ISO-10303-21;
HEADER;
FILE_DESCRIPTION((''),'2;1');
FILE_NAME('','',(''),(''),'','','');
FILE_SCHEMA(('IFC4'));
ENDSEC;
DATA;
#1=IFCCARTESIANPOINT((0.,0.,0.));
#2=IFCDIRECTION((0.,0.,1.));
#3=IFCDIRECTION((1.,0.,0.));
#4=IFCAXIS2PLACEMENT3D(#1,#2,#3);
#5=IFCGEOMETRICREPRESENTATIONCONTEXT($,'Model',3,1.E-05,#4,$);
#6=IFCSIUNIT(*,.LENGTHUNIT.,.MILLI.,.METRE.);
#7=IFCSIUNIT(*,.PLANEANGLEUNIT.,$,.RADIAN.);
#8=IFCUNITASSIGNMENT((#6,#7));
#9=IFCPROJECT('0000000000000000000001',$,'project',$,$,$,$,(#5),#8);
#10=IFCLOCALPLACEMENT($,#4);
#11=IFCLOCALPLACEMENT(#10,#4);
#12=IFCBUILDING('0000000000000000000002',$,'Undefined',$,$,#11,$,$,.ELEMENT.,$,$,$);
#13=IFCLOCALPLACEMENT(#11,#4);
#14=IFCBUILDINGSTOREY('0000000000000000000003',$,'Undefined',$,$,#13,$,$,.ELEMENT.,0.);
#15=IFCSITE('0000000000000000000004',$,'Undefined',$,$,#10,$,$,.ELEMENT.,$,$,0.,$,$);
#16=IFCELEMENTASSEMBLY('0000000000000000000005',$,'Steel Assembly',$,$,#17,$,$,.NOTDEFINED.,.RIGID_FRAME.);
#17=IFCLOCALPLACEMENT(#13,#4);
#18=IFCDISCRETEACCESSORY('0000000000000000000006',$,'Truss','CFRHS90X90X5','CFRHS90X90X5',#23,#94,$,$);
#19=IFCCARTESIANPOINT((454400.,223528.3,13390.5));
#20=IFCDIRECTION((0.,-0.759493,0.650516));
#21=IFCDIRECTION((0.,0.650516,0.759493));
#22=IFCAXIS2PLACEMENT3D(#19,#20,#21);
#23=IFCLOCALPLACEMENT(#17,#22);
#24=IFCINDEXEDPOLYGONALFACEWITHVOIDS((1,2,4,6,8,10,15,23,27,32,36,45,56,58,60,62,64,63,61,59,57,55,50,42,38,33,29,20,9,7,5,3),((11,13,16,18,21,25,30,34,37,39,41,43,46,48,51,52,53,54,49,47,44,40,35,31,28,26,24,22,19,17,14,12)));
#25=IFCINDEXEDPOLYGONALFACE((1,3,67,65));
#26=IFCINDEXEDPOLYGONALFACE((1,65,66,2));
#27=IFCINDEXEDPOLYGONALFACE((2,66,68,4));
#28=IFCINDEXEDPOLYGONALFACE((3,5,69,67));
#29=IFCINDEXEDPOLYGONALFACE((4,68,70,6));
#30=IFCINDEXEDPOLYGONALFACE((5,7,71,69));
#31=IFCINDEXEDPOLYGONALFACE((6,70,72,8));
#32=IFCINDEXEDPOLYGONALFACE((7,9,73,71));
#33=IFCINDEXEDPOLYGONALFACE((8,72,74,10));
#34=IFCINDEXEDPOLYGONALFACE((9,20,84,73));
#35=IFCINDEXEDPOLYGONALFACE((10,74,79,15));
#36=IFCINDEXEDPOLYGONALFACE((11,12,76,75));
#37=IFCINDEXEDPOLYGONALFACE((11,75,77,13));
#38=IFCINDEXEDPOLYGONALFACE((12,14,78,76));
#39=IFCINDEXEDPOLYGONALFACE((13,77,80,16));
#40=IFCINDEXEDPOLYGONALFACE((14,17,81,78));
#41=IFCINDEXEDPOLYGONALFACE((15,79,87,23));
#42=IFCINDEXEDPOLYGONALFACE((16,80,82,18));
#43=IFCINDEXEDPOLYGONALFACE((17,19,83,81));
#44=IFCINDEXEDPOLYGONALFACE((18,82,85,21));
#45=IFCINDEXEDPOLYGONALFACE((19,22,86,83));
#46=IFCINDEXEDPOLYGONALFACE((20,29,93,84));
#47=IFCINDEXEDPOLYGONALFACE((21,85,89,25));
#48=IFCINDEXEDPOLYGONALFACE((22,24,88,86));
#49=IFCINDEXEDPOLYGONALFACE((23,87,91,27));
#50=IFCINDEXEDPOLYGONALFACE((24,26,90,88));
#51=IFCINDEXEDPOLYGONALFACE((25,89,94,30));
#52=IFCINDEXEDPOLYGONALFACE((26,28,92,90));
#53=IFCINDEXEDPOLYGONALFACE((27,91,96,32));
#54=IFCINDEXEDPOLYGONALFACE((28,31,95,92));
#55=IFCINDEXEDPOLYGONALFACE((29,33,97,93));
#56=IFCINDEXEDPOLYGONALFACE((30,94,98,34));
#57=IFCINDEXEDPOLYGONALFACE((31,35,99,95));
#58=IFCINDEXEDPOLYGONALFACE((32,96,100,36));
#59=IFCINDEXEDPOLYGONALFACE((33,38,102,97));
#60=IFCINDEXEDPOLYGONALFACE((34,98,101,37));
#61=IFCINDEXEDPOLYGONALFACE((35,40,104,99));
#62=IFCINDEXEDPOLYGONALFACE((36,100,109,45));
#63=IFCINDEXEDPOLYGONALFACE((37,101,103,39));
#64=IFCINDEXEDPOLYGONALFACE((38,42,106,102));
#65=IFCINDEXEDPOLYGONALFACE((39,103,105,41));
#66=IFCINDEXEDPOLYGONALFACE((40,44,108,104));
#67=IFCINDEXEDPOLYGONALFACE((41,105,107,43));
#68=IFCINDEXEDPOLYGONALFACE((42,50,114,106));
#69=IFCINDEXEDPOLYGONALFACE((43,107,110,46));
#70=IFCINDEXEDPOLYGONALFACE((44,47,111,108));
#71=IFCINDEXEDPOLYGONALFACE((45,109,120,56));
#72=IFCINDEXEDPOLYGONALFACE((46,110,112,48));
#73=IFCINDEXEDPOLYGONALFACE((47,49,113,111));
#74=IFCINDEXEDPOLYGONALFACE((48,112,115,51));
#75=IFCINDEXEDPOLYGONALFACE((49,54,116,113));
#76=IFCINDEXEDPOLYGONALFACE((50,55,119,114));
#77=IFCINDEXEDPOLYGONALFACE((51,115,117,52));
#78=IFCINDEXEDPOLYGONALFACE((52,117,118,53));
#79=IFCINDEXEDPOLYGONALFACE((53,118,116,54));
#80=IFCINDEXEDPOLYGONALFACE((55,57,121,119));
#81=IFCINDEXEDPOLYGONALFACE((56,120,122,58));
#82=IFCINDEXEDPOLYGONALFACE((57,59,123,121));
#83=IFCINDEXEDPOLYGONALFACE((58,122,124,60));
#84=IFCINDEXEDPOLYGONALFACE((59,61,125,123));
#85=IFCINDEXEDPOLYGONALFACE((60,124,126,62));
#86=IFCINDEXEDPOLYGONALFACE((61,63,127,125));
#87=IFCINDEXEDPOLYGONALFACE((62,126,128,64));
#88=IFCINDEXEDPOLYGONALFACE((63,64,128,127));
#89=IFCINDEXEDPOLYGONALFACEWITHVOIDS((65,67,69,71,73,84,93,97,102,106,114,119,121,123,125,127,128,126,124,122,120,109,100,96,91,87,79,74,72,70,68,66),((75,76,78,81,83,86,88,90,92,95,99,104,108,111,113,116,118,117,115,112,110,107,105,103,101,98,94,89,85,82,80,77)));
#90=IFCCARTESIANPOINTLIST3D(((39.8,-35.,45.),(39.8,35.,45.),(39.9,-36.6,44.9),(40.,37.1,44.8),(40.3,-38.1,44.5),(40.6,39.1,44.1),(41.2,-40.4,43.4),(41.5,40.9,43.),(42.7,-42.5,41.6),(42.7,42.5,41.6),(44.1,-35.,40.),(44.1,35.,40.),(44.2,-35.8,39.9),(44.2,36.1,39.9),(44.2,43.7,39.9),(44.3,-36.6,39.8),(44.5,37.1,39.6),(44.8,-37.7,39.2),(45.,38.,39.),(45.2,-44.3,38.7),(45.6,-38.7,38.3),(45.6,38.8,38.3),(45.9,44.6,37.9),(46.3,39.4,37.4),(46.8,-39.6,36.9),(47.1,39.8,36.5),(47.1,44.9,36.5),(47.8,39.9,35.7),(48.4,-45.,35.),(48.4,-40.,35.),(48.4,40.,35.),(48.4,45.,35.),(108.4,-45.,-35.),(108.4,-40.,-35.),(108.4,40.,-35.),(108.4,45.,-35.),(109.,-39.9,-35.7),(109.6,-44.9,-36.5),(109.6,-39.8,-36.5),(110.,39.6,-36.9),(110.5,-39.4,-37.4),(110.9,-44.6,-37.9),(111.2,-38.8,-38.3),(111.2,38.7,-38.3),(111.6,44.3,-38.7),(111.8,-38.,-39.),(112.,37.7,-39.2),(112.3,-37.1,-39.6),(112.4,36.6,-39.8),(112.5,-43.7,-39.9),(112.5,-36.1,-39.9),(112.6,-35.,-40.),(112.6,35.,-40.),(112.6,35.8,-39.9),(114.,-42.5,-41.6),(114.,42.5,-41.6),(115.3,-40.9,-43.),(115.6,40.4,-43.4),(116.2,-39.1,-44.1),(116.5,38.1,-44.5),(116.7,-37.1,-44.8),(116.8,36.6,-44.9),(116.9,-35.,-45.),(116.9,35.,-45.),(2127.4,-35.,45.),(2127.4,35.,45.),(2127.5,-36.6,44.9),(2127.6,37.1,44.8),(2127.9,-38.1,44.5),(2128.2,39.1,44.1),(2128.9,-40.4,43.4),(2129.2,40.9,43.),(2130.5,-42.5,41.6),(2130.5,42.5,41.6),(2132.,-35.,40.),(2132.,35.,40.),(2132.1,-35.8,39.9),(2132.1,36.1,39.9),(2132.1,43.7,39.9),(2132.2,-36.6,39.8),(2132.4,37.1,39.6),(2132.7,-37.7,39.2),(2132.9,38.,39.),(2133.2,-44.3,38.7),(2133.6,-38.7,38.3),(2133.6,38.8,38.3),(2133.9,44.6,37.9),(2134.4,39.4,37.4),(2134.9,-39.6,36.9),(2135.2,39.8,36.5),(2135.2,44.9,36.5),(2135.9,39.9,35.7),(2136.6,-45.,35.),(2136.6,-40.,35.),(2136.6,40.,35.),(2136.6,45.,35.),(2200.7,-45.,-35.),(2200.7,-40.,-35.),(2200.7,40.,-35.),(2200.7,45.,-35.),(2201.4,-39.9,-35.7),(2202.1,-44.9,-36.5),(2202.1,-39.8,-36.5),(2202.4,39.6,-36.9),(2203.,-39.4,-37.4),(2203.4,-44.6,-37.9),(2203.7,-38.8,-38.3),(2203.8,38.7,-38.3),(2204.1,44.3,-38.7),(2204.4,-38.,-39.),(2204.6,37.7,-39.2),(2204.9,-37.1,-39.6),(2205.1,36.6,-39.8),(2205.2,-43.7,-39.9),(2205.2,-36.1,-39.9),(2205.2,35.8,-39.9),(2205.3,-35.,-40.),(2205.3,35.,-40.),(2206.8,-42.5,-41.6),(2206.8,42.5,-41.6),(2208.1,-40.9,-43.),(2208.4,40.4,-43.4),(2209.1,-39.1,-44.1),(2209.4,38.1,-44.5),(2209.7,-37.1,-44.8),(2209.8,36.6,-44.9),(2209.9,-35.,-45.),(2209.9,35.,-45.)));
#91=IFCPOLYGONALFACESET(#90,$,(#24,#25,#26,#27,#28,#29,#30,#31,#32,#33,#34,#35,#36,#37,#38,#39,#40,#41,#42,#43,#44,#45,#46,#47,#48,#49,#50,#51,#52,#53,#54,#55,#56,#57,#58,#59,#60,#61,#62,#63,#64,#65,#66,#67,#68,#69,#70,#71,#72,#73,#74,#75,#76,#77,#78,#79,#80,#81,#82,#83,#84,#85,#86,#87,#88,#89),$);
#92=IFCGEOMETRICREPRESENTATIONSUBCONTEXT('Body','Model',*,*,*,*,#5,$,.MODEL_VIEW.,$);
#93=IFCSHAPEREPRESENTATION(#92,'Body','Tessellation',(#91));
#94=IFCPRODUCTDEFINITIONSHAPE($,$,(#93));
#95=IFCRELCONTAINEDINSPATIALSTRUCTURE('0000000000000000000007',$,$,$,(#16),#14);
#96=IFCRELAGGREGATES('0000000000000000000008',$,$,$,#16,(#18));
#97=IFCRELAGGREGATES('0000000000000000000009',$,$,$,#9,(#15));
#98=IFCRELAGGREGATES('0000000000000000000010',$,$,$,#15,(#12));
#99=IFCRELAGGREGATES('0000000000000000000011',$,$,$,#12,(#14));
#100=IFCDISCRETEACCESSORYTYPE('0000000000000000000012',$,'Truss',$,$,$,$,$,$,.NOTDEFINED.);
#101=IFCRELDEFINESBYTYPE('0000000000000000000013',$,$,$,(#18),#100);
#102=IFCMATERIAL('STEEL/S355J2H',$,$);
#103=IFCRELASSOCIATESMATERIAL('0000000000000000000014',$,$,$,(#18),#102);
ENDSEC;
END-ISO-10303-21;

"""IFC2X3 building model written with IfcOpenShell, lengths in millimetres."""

from ifc_helpers import new_model, si_unit, frame, origin_with_axes, origin_2d_with_axis, place, context, subcontext, project, spatial, hollow_rectangle, extrude, clip, halfspace, material, type_object, element, aggregate, save


model = new_model("IFC2X3")

# Units and contexts
model_context = context("Model", 3, precision=1e-05, world=origin_with_axes())
body_context = subcontext(model_context, "Body", "Model", "MODEL_VIEW")
ifc_project = project(units=[si_unit("LENGTHUNIT", "METRE", prefix="MILLI"), si_unit("PLANEANGLEUNIT", "RADIAN")], contexts=[model_context])

# Site, building, storey
site_placement = place(None, origin_with_axes())
site = spatial("IfcSite", under=ifc_project, at=site_placement, Name="Undefined", CompositionType="ELEMENT", RefElevation=0.0)
building_placement = place(site_placement, origin_with_axes())
building = spatial("IfcBuilding", under=site, at=building_placement, Name="Undefined", CompositionType="ELEMENT")
storey_placement = place(building_placement, origin_with_axes())
storey = spatial("IfcBuildingStorey", under=building, at=storey_placement, Name="Undefined", CompositionType="ELEMENT", Elevation=0.0)

# Element assembly, discrete accessory
assembly_1_placement = place(storey_placement, origin_with_axes())
assembly_1 = element("IfcElementAssembly", 1, at=assembly_1_placement, inside=storey, Name="Steel Assembly", AssemblyPlace="NOTDEFINED", PredefinedType="RIGID_FRAME")
ifc_material_1 = material(Name="STEEL/S355J2H")
discrete_accessory_type_1 = type_object("IfcDiscreteAccessoryType", Name="Truss")
discrete_accessory_1_placement = place(assembly_1_placement, frame((454400.0, 223528.3, 13390.5), z_axis=(0.0, -0.759493, 0.650516), x_axis=(0.0, 0.650516, 0.759493)))
discrete_accessory_1 = element("IfcDiscreteAccessory", 2, at=discrete_accessory_1_placement, type_object=discrete_accessory_type_1, material=ifc_material_1, Name="Truss", Description="CFRHS90X90X5", ObjectType="CFRHS90X90X5", context=body_context, shape_type="Clipping", body=[
    clip(clip(extrude(hollow_rectangle(XDim=90.0, YDim=90.0, WallThickness=5.0, InnerFilletRadius=5.0, OuterFilletRadius=10.0, at=origin_2d_with_axis()), frame((2249.2, 0.0, 0.0), z_axis=(-1.0, 0.0, 0.0), x_axis=(0.0, -1.0, 0.0)), (0.0, 0.0, 1.0), 2251.4), halfspace(frame((2209.9, 0.0, -45.0), z_axis=(-0.737399, 0.0, -0.675457), x_axis=(-0.675457, 0.0, 0.737399)), True)), halfspace(frame((116.9, 0.0, -45.0), z_axis=(-0.759493, 0.0, -0.650516), x_axis=(-0.650516, 0.0, 0.759493)), False)),
])

aggregate(assembly_1, [discrete_accessory_1])

save(model, "model.ifc")
